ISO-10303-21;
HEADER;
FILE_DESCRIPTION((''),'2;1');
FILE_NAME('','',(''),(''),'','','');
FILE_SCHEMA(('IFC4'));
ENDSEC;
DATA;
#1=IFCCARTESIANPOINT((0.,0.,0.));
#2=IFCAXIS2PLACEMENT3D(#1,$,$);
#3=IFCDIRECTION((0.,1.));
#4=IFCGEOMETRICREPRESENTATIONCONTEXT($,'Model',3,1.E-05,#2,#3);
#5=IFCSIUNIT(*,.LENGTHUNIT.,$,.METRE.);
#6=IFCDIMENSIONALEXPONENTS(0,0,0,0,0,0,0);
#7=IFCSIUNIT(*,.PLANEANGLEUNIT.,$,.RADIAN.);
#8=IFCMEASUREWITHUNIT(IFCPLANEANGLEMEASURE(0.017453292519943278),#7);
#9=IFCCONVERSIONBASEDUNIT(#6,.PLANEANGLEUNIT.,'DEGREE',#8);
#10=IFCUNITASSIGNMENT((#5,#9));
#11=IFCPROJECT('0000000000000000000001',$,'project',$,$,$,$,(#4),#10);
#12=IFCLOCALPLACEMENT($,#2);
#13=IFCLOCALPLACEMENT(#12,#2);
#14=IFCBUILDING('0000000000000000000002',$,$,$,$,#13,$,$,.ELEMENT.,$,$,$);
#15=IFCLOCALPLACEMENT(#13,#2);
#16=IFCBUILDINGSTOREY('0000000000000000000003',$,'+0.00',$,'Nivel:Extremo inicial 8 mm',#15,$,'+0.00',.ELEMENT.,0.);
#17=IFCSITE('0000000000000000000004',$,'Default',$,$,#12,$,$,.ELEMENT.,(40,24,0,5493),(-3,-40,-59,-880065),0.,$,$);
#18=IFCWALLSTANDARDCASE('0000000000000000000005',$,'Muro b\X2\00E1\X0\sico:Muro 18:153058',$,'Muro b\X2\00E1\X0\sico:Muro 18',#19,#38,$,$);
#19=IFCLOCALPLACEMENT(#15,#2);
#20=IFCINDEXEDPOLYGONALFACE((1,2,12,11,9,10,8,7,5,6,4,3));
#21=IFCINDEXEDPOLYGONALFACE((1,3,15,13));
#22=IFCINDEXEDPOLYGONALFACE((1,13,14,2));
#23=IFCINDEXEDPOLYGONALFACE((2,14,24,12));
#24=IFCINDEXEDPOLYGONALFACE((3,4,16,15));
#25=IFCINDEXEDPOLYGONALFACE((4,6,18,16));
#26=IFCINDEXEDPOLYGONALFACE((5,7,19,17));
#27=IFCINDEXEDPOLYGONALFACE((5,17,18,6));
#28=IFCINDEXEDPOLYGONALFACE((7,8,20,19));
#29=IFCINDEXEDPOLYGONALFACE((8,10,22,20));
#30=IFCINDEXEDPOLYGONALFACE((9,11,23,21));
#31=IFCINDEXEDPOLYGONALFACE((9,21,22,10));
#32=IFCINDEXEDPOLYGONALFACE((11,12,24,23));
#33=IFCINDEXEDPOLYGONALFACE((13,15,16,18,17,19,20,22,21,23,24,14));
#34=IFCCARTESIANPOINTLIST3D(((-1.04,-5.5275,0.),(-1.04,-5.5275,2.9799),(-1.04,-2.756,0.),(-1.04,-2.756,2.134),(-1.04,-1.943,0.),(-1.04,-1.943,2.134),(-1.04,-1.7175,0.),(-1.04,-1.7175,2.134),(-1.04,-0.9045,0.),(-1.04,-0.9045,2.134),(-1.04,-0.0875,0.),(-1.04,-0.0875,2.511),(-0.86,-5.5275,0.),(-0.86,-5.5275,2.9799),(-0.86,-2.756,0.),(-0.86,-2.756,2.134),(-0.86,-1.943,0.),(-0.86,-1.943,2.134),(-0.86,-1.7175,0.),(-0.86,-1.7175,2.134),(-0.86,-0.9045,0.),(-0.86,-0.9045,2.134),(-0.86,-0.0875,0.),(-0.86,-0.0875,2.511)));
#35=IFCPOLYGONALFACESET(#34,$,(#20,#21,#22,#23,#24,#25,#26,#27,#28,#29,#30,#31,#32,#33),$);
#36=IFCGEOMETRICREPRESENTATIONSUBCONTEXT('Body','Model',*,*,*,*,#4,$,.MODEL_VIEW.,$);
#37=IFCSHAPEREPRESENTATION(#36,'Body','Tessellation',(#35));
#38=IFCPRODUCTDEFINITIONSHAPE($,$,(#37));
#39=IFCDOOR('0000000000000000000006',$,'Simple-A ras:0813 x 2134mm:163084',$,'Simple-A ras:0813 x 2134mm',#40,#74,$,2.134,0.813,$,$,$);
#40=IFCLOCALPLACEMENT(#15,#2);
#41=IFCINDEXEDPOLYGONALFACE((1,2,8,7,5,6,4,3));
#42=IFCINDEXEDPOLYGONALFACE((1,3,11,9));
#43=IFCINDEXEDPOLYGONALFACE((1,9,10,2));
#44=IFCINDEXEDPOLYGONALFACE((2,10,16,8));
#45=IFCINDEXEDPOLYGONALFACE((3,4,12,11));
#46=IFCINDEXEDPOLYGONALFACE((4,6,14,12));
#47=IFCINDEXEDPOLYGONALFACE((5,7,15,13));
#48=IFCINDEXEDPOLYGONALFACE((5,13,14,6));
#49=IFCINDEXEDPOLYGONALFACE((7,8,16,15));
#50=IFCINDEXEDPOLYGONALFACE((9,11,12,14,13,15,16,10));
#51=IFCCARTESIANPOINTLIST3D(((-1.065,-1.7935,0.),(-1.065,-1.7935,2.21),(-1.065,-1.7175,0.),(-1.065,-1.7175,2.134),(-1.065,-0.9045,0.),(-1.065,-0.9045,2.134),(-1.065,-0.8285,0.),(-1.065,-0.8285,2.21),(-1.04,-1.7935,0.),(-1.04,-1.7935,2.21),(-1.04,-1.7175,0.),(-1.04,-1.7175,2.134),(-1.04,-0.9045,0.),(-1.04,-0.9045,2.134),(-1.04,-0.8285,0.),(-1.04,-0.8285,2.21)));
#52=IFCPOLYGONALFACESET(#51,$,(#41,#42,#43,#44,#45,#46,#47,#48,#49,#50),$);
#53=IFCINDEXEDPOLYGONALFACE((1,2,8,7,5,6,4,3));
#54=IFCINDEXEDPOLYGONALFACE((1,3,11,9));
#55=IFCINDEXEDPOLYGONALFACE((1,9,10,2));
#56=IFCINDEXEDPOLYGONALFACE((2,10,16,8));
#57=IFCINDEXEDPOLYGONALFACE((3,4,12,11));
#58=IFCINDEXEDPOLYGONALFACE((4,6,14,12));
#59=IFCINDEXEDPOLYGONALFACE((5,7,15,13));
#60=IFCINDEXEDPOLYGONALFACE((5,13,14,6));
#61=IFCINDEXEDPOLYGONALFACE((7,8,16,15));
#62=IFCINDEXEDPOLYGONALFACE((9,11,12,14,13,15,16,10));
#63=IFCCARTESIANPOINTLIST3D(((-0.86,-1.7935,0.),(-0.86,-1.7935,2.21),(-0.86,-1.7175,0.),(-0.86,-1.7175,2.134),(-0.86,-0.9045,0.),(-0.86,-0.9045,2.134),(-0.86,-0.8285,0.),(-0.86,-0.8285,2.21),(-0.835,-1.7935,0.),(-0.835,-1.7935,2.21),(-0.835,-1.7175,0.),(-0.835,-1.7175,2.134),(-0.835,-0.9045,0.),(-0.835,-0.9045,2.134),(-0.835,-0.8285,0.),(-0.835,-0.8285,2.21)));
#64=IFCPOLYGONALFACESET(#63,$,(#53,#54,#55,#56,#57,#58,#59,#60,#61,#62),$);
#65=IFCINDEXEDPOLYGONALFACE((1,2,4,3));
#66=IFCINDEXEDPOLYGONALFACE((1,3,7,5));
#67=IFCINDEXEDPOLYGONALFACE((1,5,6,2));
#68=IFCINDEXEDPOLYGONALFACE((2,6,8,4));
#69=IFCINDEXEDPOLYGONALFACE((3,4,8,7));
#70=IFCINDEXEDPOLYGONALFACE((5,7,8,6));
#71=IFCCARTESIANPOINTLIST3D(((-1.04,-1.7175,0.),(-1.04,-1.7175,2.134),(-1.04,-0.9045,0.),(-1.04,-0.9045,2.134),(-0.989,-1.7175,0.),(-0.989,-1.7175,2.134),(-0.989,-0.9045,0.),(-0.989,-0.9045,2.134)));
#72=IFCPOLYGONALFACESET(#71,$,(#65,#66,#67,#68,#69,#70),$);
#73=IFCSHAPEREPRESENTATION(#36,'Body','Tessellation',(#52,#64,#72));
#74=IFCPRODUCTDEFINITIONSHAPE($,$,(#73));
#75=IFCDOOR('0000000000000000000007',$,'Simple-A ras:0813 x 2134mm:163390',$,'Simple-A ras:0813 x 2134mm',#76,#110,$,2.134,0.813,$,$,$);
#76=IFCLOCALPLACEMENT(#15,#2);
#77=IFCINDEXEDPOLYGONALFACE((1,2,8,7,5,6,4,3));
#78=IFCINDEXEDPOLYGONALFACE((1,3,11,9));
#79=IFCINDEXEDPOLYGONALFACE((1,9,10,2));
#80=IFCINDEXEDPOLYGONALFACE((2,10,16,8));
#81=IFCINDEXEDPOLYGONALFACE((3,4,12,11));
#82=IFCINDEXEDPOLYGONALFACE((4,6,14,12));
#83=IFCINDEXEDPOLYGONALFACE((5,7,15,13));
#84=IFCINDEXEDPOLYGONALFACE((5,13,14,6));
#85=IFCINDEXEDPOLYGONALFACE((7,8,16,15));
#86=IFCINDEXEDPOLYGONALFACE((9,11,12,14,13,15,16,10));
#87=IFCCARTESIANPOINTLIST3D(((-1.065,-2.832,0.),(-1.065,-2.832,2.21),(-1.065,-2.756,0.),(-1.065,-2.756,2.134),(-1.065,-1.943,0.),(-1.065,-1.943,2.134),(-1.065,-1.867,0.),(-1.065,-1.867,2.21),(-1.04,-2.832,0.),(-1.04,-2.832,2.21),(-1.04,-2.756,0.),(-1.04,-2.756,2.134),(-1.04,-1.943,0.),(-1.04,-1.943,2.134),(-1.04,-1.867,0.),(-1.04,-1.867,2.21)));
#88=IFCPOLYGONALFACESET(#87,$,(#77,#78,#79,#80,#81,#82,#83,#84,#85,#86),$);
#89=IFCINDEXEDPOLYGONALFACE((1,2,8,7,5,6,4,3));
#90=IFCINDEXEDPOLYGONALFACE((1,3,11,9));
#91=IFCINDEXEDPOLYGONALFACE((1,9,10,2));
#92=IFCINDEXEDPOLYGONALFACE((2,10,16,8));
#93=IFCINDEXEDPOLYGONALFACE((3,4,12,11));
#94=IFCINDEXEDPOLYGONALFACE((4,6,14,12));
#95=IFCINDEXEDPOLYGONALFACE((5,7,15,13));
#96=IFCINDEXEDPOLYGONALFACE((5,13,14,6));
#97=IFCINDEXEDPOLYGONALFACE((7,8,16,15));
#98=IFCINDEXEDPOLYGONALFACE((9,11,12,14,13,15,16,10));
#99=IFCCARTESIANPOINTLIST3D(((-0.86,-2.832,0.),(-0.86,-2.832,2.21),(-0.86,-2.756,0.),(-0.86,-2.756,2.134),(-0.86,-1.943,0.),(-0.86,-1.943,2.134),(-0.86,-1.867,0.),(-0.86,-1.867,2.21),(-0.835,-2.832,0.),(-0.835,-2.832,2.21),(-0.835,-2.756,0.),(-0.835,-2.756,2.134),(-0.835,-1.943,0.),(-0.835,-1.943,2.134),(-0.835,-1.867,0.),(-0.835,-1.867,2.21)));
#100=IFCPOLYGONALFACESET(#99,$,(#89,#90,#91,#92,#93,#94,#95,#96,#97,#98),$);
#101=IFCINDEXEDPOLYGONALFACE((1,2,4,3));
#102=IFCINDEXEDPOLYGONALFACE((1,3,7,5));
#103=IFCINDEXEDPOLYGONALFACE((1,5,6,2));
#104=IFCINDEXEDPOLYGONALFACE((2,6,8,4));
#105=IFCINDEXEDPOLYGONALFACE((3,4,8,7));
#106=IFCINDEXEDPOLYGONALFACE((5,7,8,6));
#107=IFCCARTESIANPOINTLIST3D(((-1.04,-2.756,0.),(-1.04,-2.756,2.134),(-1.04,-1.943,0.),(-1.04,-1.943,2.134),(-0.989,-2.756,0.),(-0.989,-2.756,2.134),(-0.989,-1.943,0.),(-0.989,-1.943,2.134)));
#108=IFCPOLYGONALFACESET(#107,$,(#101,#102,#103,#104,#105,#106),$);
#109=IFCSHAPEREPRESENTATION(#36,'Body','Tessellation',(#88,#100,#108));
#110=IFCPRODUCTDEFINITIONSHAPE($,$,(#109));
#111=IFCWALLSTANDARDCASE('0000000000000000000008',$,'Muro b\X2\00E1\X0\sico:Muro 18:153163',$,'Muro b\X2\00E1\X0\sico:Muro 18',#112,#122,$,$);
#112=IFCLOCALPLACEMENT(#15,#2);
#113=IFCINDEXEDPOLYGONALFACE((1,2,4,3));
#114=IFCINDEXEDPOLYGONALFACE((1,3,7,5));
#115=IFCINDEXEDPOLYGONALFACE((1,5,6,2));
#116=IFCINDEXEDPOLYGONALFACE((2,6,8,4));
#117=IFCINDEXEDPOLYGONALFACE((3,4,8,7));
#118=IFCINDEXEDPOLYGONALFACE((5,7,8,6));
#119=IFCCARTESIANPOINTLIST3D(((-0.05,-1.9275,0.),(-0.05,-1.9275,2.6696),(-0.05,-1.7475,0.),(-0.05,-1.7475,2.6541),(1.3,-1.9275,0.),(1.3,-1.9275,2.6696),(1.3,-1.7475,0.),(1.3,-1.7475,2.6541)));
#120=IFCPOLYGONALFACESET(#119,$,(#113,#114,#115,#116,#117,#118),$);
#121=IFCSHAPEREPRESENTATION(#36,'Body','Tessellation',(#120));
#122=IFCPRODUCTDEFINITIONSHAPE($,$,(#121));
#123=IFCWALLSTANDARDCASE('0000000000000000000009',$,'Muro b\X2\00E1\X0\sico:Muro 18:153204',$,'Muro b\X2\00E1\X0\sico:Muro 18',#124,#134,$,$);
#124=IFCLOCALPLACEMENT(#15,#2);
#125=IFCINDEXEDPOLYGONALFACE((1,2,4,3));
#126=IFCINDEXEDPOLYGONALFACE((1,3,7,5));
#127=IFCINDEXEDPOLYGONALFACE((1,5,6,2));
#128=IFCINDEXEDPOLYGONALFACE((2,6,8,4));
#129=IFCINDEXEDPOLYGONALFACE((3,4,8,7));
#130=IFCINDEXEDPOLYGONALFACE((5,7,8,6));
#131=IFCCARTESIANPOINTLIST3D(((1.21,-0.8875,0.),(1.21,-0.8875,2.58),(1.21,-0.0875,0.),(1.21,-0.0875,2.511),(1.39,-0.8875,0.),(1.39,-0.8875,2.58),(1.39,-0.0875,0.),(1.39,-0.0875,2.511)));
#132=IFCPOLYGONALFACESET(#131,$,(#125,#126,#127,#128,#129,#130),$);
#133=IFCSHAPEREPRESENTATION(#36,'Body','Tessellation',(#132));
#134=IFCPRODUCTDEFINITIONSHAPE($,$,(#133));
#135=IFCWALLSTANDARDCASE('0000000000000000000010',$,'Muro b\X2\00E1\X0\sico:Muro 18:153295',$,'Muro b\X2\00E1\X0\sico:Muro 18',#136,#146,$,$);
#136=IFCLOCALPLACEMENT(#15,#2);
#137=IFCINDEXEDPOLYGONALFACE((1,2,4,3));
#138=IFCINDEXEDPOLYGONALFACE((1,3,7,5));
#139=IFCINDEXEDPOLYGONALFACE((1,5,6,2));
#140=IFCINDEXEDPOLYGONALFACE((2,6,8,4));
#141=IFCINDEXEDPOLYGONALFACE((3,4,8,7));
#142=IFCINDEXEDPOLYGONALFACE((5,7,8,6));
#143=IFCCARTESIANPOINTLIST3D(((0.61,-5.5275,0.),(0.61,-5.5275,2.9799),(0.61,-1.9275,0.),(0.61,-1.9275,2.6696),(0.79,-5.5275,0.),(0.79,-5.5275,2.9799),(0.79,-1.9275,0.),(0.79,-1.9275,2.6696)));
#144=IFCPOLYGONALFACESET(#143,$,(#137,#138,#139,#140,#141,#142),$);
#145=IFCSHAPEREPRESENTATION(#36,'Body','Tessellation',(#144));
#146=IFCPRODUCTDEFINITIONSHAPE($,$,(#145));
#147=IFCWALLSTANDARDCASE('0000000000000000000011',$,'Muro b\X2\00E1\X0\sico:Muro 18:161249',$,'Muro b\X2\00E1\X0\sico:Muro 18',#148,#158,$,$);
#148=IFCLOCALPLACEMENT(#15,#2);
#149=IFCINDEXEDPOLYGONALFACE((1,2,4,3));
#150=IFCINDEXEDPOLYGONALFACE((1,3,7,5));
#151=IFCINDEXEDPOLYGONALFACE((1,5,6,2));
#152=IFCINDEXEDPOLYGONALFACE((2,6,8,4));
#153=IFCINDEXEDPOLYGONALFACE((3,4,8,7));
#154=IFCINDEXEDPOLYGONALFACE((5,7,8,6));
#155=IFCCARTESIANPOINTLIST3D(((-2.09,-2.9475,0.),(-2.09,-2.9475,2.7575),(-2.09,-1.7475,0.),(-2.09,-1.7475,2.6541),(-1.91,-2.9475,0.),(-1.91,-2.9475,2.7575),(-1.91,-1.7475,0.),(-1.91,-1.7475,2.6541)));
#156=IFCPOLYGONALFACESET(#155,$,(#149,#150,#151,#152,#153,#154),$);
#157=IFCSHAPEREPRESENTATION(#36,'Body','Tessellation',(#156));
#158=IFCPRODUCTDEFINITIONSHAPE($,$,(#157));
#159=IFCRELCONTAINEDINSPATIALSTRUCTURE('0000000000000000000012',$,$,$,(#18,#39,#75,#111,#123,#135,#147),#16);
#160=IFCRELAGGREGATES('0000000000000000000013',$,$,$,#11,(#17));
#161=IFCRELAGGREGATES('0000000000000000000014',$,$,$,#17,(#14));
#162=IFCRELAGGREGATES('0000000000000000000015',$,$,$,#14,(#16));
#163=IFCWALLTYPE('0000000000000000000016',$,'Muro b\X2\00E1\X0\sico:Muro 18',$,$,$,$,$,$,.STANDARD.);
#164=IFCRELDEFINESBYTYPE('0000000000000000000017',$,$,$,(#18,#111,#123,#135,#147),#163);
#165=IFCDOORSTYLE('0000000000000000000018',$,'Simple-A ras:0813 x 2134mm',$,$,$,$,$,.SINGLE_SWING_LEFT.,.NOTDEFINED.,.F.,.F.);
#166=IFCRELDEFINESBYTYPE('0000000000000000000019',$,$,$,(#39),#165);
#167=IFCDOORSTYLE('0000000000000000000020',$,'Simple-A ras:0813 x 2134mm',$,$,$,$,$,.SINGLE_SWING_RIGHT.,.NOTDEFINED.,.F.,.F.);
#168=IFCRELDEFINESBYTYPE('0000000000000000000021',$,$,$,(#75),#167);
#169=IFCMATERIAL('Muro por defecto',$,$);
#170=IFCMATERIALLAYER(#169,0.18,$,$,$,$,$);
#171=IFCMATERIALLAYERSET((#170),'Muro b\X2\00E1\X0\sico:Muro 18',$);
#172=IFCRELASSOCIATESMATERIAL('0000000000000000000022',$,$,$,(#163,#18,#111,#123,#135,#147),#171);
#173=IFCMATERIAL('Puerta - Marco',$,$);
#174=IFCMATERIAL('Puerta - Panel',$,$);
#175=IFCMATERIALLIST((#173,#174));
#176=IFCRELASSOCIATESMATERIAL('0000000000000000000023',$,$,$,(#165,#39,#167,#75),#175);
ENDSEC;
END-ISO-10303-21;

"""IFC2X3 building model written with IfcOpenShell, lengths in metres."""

from ifc_helpers import new_model, entity, si_unit, converted_unit, direction, frame, frame_2d, origin, place, context, subcontext, project, spatial, polyline, rectangle, outline, extrude, clip, bounded_halfspace, source, transform, mapped, material, material_list, layer, layer_set, layer_usage, type_object, type_shapes, element, fill, save


model = new_model("IFC2X3")

# Units and contexts
model_context = context("Model", 3, precision=1e-05, world=origin(), true_north=direction((0.0, 1.0)))
body_context = subcontext(model_context, "Body", "Model", "MODEL_VIEW")
ifc_project = project(units=[si_unit("LENGTHUNIT", "METRE"), converted_unit("PLANEANGLEUNIT", "DEGREE", entity("IfcPlaneAngleMeasure", 0.017453292519943278), si_unit("PLANEANGLEUNIT", "RADIAN"), dimensions=[0, 0, 0, 0, 0, 0, 0])], contexts=[model_context])

# Site, building, storey
site_placement = place(None, origin())
site = spatial("IfcSite", under=ifc_project, at=site_placement, Name="Default", CompositionType="ELEMENT", RefLatitude=(40, 24, 0, 5493), RefLongitude=(-3, -40, -59, -880065), RefElevation=0.0)
building_placement = place(site_placement, origin())
building = spatial("IfcBuilding", under=site, at=building_placement, CompositionType="ELEMENT")
storey_placement = place(building_placement, origin())
storey = spatial("IfcBuildingStorey", under=building, at=storey_placement, Name="+0.00", ObjectType="Nivel:Extremo inicial 8 mm", LongName="+0.00", CompositionType="ELEMENT", Elevation=0.0)

# Shared definitions
ifc_material_1 = material(Name="Muro por defecto")
ifc_layer = layer(ifc_material_1, 0.18)
ifc_layer_set = layer_set([ifc_layer], Name="Muro básico:Muro 18")
wall_type = type_object("IfcWallType", Name="Muro básico:Muro 18", PredefinedType="STANDARD", material=ifc_layer_set)

# Shared definitions
ifc_material_2 = material(Name="Puerta - Marco")
ifc_material_3 = material(Name="Puerta - Panel")
ifc_material_list_1 = material_list([ifc_material_2, ifc_material_3])

# Wall, openings, doors
ifc_layer_usage_1 = layer_usage(ifc_layer_set, "AXIS2", "NEGATIVE", 0.09)
wall_1_placement = place(storey_placement, frame((-0.95, -5.5275, 0.0), z_axis=(0.0, 0.0, 1.0), x_axis=(0.0, 1.0, 0.0)))
wall_1 = element("IfcWallStandardCase", 1, at=wall_1_placement, inside=storey, type_object=wall_type, material=ifc_layer_usage_1, Name="Muro básico:Muro 18:153058", ObjectType="Muro básico:Muro 18", context=body_context, shape_type="Clipping", body=[
    clip(extrude(rectangle(XDim=5.44, YDim=0.18, at=frame_2d((2.72, 0.0), x_axis=(1.0, 0.0))), origin(), (0.0, 0.0, 1.0), 2.9799), bounded_halfspace(frame((0.0, -0.09, 2.9799), z_axis=(0.085882, 0.0, 0.996305), x_axis=(0.0, 1.0, 0.0)), False, frame((0.0, -0.09, 2.9799)), polyline([(0.0, 0.0), (5.44, 0.0), (5.44, 0.18), (0.0, 0.18), (0.0, 0.0)]))),
])
opening_1_placement = place(wall_1_placement, frame((3.81, -0.09, 0.0)))
opening_1 = element("IfcOpeningElement", 2, at=opening_1_placement, cuts=wall_1, ObjectType="Opening", context=body_context, shape_type="SweptSolid", body=[
    extrude(rectangle(XDim=0.813, YDim=2.134, at=frame_2d((1.067, 0.4065), x_axis=(0.0, -1.0))), frame((0.0, 0.0, 0.0), z_axis=(0.0, 1.0, 0.0), x_axis=(0.0, 0.0, 1.0)), (0.0, 0.0, 1.0), 0.18),
])
opening_2_placement = place(wall_1_placement, frame((2.7715, -0.09, 0.0)))
opening_2 = element("IfcOpeningElement", 3, at=opening_2_placement, cuts=wall_1, ObjectType="Opening", context=body_context, shape_type="SweptSolid", body=[
    extrude(rectangle(XDim=0.813, YDim=2.134, at=frame_2d((1.067, 0.4065), x_axis=(0.0, 1.0))), frame((0.0, 0.0, 0.0), z_axis=(0.0, 1.0, 0.0), x_axis=(0.0, 0.0, 1.0)), (0.0, 0.0, 1.0), 0.18),
])
door_style_1 = type_object("IfcDoorStyle", Name="Simple-A ras:0813 x 2134mm", ConstructionType="NOTDEFINED", OperationType="SINGLE_SWING_LEFT", ParameterTakesPrecedence=False, Sizeable=False, material=ifc_material_list_1)
shared_shape_1 = source(origin(), body_context, "Body", "SweptSolid", [
    extrude(outline(polyline([(-0.4825, -1.124), (0.4825, -1.124), (0.4825, 1.086), (0.4065, 1.086), (0.4065, -1.048), (-0.4065, -1.048), (-0.4065, 1.086), (-0.4825, 1.086), (-0.4825, -1.124)])), frame((0.4065, 0.205, 1.086), z_axis=(0.0, -1.0, 0.0), x_axis=(-1.0, 0.0, 0.0)), (0.0, 0.0, 1.0), 0.025),
    extrude(outline(polyline([(-1.124, -0.4825), (1.086, -0.4825), (1.086, -0.4065), (-1.048, -0.4065), (-1.048, 0.4065), (1.086, 0.4065), (1.086, 0.4825), (-1.124, 0.4825), (-1.124, -0.4825)])), frame((0.4065, 0.0, 1.086), z_axis=(0.0, -1.0, 0.0), x_axis=(0.0, 0.0, -1.0)), (0.0, 0.0, 1.0), 0.025),
    extrude(rectangle(XDim=0.813, YDim=0.051, at=frame_2d((0.0, 0.0), x_axis=(1.0, 0.0))), frame((0.4065, 0.1545, 0.0)), (0.0, 0.0, 1.0), 2.134),
])
type_shapes(door_style_1, [shared_shape_1])
door_1_placement = place(opening_1_placement, origin())
door_1 = element("IfcDoor", 4, at=door_1_placement, inside=storey, type_object=door_style_1, material=ifc_material_list_1, Name="Simple-A ras:0813 x 2134mm:163084", ObjectType="Simple-A ras:0813 x 2134mm", OverallHeight=2.134, OverallWidth=0.813, context=body_context, shape_type="MappedRepresentation", body=[
    mapped(shared_shape_1, transform((0.0, 0.0, 0.0), scale=1.0)),
])
fill(opening_1, door_1)
door_style_2 = type_object("IfcDoorStyle", Name="Simple-A ras:0813 x 2134mm", ConstructionType="NOTDEFINED", OperationType="SINGLE_SWING_RIGHT", ParameterTakesPrecedence=False, Sizeable=False, material=ifc_material_list_1)
shared_shape_2 = source(origin(), body_context, "Body", "SweptSolid", [
    extrude(outline(polyline([(-0.4825, -1.124), (0.4825, -1.124), (0.4825, 1.086), (0.4065, 1.086), (0.4065, -1.048), (-0.4065, -1.048), (-0.4065, 1.086), (-0.4825, 1.086), (-0.4825, -1.124)])), frame((0.4065, 0.18, 1.086), z_axis=(0.0, 1.0, 0.0), x_axis=(1.0, 0.0, 0.0)), (0.0, 0.0, 1.0), 0.025),
    extrude(outline(polyline([(-1.124, -0.4825), (1.086, -0.4825), (1.086, -0.4065), (-1.048, -0.4065), (-1.048, 0.4065), (1.086, 0.4065), (1.086, 0.4825), (-1.124, 0.4825), (-1.124, -0.4825)])), frame((0.4065, -0.025, 1.086), z_axis=(0.0, 1.0, 0.0), x_axis=(0.0, 0.0, -1.0)), (0.0, 0.0, 1.0), 0.025),
    extrude(rectangle(XDim=0.051, YDim=0.813, at=frame_2d((0.0, 0.0), x_axis=(1.0, 0.0))), frame((0.4065, 0.1545, 0.0), z_axis=(0.0, 0.0, 1.0), x_axis=(0.0, 1.0, 0.0)), (0.0, 0.0, 1.0), 2.134),
])
type_shapes(door_style_2, [shared_shape_2])
door_2_placement = place(opening_2_placement, origin())
door_2 = element("IfcDoor", 5, at=door_2_placement, inside=storey, type_object=door_style_2, material=ifc_material_list_1, Name="Simple-A ras:0813 x 2134mm:163390", ObjectType="Simple-A ras:0813 x 2134mm", OverallHeight=2.134, OverallWidth=0.813, context=body_context, shape_type="MappedRepresentation", body=[
    mapped(shared_shape_2, transform((0.0, 0.0, 0.0), scale=1.0)),
])
fill(opening_2, door_2)

# Walls
ifc_layer_usage_2 = layer_usage(ifc_layer_set, "AXIS2", "NEGATIVE", 0.09)
wall_2_placement = place(storey_placement, frame((-0.05, -1.8375, 0.0)))
element("IfcWallStandardCase", 6, at=wall_2_placement, inside=storey, type_object=wall_type, material=ifc_layer_usage_2, Name="Muro básico:Muro 18:153163", ObjectType="Muro básico:Muro 18", context=body_context, shape_type="Clipping", body=[
    clip(extrude(rectangle(XDim=1.35, YDim=0.18, at=frame_2d((0.675, 0.0), x_axis=(-1.0, 0.0))), origin(), (0.0, 0.0, 1.0), 2.6696), bounded_halfspace(frame((0.0, -0.09, 2.6696), z_axis=(0.0, 0.085882, 0.996305), x_axis=(-1.0, 0.0, 0.0)), False, frame((0.0, -0.09, 2.6696)), polyline([(0.0, 0.0), (0.66, 0.0), (0.84, 0.0), (1.35, 0.0), (1.35, 0.18), (0.0, 0.18), (0.0, 0.0)]))),
])
ifc_layer_usage_3 = layer_usage(ifc_layer_set, "AXIS2", "POSITIVE", -0.09)
wall_3_placement = place(storey_placement, frame((1.3, -0.8875, 0.0), z_axis=(0.0, 0.0, 1.0), x_axis=(0.0, 1.0, 0.0)))
element("IfcWallStandardCase", 7, at=wall_3_placement, inside=storey, type_object=wall_type, material=ifc_layer_usage_3, Name="Muro básico:Muro 18:153204", ObjectType="Muro básico:Muro 18", context=body_context, shape_type="Clipping", body=[
    clip(extrude(rectangle(XDim=0.8, YDim=0.18, at=frame_2d((0.4, 0.0), x_axis=(-1.0, 0.0))), origin(), (0.0, 0.0, 1.0), 2.58), bounded_halfspace(frame((0.0, -0.09, 2.58), z_axis=(0.085882, 0.0, 0.996305), x_axis=(0.0, 1.0, 0.0)), False, frame((0.0, -0.09, 2.58)), polyline([(0.0, 0.0), (0.8, 0.0), (0.8, 0.18), (0.0, 0.18), (0.0, 0.0)]))),
])
ifc_layer_usage_4 = layer_usage(ifc_layer_set, "AXIS2", "NEGATIVE", 0.09)
wall_4_placement = place(storey_placement, frame((0.7, -5.5275, 0.0), z_axis=(0.0, 0.0, 1.0), x_axis=(0.0, 1.0, 0.0)))
element("IfcWallStandardCase", 8, at=wall_4_placement, inside=storey, type_object=wall_type, material=ifc_layer_usage_4, Name="Muro básico:Muro 18:153295", ObjectType="Muro básico:Muro 18", context=body_context, shape_type="Clipping", body=[
    clip(extrude(rectangle(XDim=3.6, YDim=0.18, at=frame_2d((1.8, 0.0), x_axis=(-1.0, 0.0))), origin(), (0.0, 0.0, 1.0), 2.9799), bounded_halfspace(frame((0.0, -0.09, 2.9799), z_axis=(0.085882, 0.0, 0.996305), x_axis=(0.0, 1.0, 0.0)), False, frame((0.0, -0.09, 2.9799)), polyline([(0.0, 0.0), (3.6, 0.0), (3.6, 0.18), (0.0, 0.18), (0.0, 0.0)]))),
])
ifc_layer_usage_5 = layer_usage(ifc_layer_set, "AXIS2", "NEGATIVE", 0.09)
wall_5_placement = place(storey_placement, frame((-2.0, -2.9475, 0.0), z_axis=(0.0, 0.0, 1.0), x_axis=(0.0, 1.0, 0.0)))
element("IfcWallStandardCase", 9, at=wall_5_placement, inside=storey, type_object=wall_type, material=ifc_layer_usage_5, Name="Muro básico:Muro 18:161249", ObjectType="Muro básico:Muro 18", context=body_context, shape_type="Clipping", body=[
    clip(extrude(rectangle(XDim=1.2, YDim=0.18, at=frame_2d((0.6, 0.0), x_axis=(-1.0, 0.0))), origin(), (0.0, 0.0, 1.0), 2.7575), bounded_halfspace(frame((0.0, -0.09, 2.7575), z_axis=(0.085882, 0.0, 0.996305), x_axis=(0.0, 1.0, 0.0)), False, frame((0.0, -0.09, 2.7575)), polyline([(0.0, 0.0), (1.02, 0.0), (1.2, 0.0), (1.2, 0.18), (0.18, 0.18), (0.0, 0.18), (0.0, 0.0)]))),
])

save(model, "model.ifc")
